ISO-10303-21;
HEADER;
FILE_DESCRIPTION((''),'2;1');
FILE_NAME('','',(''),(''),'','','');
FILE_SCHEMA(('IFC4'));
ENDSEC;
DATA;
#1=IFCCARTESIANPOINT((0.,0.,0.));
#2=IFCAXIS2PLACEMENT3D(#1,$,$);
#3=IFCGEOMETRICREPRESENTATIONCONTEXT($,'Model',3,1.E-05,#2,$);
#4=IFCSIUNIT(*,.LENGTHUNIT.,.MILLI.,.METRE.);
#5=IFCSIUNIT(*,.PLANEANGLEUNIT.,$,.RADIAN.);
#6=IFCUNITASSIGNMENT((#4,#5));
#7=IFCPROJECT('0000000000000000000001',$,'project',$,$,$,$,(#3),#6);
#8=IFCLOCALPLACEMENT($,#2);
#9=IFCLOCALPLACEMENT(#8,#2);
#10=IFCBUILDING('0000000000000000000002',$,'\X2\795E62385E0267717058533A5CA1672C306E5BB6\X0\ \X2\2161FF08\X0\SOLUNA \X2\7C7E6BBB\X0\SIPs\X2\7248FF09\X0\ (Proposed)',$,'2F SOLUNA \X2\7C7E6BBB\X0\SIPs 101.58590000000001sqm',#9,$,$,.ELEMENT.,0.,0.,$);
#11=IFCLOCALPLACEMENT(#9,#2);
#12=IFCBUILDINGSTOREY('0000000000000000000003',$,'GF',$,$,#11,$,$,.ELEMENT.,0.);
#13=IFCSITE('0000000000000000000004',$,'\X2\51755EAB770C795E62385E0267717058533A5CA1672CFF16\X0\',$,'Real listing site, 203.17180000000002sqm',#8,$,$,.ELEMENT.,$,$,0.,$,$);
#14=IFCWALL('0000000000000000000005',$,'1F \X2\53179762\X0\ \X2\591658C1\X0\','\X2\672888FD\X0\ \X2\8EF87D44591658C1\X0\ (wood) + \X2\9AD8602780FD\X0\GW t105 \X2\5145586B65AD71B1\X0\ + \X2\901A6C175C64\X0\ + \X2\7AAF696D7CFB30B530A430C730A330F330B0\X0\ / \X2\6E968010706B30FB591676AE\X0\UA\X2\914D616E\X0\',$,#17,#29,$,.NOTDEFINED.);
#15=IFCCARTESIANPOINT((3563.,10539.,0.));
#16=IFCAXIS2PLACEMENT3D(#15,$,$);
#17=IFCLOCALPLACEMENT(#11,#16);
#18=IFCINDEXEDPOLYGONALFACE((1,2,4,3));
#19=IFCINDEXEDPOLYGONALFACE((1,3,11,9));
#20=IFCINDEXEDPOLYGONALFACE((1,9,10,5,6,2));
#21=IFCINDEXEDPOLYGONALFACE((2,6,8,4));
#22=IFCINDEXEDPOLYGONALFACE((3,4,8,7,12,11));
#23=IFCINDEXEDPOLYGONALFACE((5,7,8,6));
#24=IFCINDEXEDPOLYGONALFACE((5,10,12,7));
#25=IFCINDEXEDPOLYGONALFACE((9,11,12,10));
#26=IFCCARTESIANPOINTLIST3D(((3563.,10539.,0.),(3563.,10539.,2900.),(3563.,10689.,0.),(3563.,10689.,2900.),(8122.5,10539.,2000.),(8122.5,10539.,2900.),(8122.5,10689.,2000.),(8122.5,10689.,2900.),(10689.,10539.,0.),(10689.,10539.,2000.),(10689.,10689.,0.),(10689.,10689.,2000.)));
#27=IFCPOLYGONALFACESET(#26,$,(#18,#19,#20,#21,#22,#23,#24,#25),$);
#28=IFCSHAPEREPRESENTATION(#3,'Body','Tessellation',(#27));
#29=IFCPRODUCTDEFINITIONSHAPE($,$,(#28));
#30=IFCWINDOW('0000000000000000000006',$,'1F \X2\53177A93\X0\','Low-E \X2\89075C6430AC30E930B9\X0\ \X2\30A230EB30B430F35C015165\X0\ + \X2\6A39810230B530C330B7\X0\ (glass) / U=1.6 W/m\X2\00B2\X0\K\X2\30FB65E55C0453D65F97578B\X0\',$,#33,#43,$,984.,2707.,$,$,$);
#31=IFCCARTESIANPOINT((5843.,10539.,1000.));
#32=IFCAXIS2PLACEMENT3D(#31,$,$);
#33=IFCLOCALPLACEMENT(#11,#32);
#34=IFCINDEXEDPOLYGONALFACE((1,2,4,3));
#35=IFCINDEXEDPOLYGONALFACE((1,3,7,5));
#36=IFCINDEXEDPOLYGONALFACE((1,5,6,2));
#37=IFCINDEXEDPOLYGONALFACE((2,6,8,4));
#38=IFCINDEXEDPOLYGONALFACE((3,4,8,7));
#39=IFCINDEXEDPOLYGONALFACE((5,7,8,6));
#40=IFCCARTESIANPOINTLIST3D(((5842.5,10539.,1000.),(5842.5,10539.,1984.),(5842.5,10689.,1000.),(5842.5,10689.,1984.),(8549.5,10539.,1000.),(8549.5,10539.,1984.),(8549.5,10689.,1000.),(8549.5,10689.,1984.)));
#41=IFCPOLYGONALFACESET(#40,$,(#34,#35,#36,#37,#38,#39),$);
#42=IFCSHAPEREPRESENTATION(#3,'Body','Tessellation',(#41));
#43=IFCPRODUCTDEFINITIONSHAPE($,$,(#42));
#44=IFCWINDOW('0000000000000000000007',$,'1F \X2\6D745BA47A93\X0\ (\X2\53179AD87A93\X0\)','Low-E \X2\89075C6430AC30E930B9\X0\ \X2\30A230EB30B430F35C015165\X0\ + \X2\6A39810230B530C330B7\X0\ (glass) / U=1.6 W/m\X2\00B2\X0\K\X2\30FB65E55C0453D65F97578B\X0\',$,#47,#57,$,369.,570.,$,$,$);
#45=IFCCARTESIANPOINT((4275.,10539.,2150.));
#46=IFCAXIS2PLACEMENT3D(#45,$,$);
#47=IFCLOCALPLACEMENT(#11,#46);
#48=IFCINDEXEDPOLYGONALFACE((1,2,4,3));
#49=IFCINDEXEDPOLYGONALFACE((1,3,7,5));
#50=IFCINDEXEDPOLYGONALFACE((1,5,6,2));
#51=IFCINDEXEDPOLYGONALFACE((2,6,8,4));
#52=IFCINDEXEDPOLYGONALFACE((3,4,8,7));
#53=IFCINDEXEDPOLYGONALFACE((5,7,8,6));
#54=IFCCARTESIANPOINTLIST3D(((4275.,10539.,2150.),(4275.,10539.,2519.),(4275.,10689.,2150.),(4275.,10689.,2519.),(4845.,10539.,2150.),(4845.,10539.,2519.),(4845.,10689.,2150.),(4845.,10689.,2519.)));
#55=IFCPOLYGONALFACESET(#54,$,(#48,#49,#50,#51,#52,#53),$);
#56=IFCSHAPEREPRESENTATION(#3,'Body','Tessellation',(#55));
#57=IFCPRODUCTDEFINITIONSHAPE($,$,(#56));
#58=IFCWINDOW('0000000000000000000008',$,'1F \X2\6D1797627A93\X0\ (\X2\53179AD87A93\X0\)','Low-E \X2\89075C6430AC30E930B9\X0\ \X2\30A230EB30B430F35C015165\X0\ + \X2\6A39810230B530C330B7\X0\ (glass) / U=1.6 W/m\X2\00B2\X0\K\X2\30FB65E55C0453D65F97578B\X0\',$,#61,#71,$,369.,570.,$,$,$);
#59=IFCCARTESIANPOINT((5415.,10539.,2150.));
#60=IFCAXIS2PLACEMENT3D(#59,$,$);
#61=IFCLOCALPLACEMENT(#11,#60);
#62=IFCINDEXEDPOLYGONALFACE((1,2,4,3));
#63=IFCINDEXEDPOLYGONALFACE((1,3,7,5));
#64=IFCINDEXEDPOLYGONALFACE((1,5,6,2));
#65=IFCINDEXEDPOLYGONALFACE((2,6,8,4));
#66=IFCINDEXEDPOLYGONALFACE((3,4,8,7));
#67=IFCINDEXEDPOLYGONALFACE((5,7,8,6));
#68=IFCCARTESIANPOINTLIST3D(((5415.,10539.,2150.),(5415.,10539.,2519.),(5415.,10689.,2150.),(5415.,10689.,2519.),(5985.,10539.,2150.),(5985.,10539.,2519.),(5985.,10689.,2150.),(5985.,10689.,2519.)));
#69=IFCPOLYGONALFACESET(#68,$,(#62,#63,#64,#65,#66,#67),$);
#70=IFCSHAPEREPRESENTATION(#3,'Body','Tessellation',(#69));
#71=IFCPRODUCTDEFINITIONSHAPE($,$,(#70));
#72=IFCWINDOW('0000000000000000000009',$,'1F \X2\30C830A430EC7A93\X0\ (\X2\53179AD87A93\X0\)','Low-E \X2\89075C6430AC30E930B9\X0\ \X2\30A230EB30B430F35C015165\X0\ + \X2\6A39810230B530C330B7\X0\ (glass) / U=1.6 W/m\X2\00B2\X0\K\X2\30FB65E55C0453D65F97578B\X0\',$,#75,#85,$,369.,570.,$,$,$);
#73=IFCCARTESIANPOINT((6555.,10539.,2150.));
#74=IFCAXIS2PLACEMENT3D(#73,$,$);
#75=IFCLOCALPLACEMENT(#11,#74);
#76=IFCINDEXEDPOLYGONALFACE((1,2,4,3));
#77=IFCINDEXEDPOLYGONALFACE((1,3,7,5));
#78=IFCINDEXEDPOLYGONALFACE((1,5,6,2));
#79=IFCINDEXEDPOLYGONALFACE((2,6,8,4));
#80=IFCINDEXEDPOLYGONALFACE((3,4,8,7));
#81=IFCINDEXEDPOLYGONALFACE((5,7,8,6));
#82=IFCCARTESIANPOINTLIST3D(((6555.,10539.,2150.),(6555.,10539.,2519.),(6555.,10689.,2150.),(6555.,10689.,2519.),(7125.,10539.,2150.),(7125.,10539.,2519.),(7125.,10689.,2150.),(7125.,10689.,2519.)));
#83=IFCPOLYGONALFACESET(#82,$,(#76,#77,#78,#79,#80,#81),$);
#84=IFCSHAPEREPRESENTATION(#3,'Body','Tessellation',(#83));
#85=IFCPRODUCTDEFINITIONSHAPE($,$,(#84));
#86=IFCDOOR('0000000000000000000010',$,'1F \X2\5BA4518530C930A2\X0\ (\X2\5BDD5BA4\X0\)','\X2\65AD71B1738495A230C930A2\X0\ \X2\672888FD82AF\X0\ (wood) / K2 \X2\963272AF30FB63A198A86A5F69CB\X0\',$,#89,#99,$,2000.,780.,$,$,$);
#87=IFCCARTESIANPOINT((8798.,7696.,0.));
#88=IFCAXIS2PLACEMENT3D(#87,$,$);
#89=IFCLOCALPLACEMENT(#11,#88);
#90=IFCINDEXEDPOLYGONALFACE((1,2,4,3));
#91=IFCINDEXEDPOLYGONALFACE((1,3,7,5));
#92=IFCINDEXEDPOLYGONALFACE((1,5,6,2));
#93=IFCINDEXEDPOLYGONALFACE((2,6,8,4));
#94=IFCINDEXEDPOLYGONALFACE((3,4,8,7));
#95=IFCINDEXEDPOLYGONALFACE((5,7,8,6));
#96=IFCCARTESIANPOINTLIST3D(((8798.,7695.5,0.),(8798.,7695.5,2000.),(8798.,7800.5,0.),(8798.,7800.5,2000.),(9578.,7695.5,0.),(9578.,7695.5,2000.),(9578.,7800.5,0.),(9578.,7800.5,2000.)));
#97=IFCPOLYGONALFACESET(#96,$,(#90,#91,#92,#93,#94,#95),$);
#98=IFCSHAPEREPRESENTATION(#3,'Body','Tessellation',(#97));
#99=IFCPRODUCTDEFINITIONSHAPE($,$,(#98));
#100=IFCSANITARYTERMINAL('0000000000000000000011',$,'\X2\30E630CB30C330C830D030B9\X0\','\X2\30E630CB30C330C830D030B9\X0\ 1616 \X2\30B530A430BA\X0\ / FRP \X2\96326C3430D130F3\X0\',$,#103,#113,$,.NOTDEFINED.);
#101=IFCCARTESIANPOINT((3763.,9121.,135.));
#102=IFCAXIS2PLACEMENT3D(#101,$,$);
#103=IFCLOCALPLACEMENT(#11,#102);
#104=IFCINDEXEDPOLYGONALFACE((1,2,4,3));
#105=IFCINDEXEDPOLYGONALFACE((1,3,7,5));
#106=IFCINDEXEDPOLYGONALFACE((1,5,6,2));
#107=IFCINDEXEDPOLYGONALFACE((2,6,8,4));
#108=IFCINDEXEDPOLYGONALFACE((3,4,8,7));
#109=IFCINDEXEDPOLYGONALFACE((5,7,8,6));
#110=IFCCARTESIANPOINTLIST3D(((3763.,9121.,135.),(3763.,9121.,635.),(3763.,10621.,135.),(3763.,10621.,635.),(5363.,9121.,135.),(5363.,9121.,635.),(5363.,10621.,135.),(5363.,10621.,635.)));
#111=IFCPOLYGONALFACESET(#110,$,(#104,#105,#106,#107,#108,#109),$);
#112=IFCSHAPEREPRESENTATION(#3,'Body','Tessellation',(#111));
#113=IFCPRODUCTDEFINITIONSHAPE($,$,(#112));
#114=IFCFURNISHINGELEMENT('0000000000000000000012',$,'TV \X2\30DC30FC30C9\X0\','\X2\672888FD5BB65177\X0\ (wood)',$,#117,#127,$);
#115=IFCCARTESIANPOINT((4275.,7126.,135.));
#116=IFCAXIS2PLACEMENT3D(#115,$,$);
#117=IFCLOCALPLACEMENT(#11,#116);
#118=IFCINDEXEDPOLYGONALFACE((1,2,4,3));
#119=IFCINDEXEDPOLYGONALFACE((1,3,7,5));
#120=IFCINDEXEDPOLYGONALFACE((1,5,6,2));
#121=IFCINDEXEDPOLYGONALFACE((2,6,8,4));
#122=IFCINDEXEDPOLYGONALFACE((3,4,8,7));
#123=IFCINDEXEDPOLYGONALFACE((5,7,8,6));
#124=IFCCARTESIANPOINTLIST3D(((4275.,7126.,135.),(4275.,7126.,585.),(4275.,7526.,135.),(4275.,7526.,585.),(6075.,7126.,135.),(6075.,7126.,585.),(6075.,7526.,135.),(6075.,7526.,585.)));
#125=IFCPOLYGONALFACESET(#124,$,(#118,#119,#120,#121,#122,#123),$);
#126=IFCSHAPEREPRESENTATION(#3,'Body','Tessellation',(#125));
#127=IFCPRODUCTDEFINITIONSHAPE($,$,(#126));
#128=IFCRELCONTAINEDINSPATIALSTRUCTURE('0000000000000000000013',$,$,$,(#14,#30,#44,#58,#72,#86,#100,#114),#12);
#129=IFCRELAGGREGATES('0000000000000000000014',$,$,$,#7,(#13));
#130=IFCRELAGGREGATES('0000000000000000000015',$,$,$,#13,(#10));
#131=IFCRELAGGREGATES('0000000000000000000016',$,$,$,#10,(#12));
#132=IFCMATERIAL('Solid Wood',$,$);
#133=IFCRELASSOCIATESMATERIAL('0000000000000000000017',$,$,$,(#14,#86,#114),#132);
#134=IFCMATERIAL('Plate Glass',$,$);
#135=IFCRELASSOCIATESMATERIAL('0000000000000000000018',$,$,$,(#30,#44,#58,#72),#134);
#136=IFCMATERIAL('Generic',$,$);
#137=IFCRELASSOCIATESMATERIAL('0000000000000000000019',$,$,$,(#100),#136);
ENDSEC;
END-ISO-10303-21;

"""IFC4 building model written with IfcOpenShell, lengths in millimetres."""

from ifc_helpers import new_model, si_unit, frame, frame_2d, origin, place, context, project, spatial, rectangle, extrude, material, element, fill, save


model = new_model("IFC4")

# Units and contexts
model_context = context("Model", 3, precision=1e-05, world=origin())
ifc_project = project(units=[si_unit("LENGTHUNIT", "METRE", prefix="MILLI"), si_unit("PLANEANGLEUNIT", "RADIAN")], contexts=[model_context])

# Site, building, storey
site_placement = place(None, origin())
site = spatial("IfcSite", under=ifc_project, at=site_placement, Name="兵庫県神戸市東灘区岡本６", ObjectType="Real listing site, 203.17180000000002sqm", CompositionType="ELEMENT", RefElevation=0.0)
building_placement = place(site_placement, origin())
building = spatial("IfcBuilding", under=site, at=building_placement, Name="神戸市東灘区岡本の家 Ⅱ（SOLUNA 籾殻SIPs版） (Proposed)", ObjectType="2F SOLUNA 籾殻SIPs 101.58590000000001sqm", CompositionType="ELEMENT", ElevationOfRefHeight=0.0, ElevationOfTerrain=0.0)
storey_placement = place(building_placement, origin())
storey = spatial("IfcBuildingStorey", under=building, at=storey_placement, Name="GF", CompositionType="ELEMENT", Elevation=0.0)

# Wall, openings, windows
ifc_material_1 = material(Name="Solid Wood")
wall_1_placement = place(storey_placement, frame((3563.0, 10539.0, 0.0)))
wall_1 = element("IfcWall", 1, at=wall_1_placement, inside=storey, material=ifc_material_1, Name="1F 北面 外壁", Description="木製 軸組外壁 (wood) + 高性能GW t105 充填断熱 + 通気層 + 窯業系サイディング / 準耐火・外皮UA配慮", PredefinedType="NOTDEFINED", context=model_context, shape_type="SweptSolid", body=[
    extrude(rectangle(XDim=7126.0, YDim=150.0, at=frame_2d((3563.0, 75.0))), frame((3563.0, 10539.0, 0.0)), (0.0, 0.0, 1.0), 2900.0),
])
opening_1_placement = place(storey_placement, frame((5843.0, 10539.0, 1000.0)))
opening_1 = element("IfcOpeningElement", 2, at=opening_1_placement, cuts=wall_1, PredefinedType="NOTDEFINED", context=model_context, shape_type="SweptSolid", body=[
    extrude(rectangle(XDim=2707.0, YDim=150.0, at=frame_2d((1353.0, 75.0))), frame((5843.0, 10539.0, 1000.0)), (0.0, 0.0, 1.0), 984.0),
])
opening_2_placement = place(storey_placement, frame((4275.0, 10539.0, 2150.0)))
opening_2 = element("IfcOpeningElement", 3, at=opening_2_placement, cuts=wall_1, PredefinedType="NOTDEFINED", context=model_context, shape_type="SweptSolid", body=[
    extrude(rectangle(XDim=570.0, YDim=150.0, at=frame_2d((285.0, 75.0))), frame((4275.0, 10539.0, 2150.0)), (0.0, 0.0, 1.0), 369.0),
])
opening_3_placement = place(storey_placement, frame((5415.0, 10539.0, 2150.0)))
opening_3 = element("IfcOpeningElement", 4, at=opening_3_placement, cuts=wall_1, PredefinedType="NOTDEFINED", context=model_context, shape_type="SweptSolid", body=[
    extrude(rectangle(XDim=570.0, YDim=150.0, at=frame_2d((285.0, 75.0))), frame((5415.0, 10539.0, 2150.0)), (0.0, 0.0, 1.0), 369.0),
])
opening_4_placement = place(storey_placement, frame((6555.0, 10539.0, 2150.0)))
opening_4 = element("IfcOpeningElement", 5, at=opening_4_placement, cuts=wall_1, PredefinedType="NOTDEFINED", context=model_context, shape_type="SweptSolid", body=[
    extrude(rectangle(XDim=570.0, YDim=150.0, at=frame_2d((285.0, 75.0))), frame((6555.0, 10539.0, 2150.0)), (0.0, 0.0, 1.0), 369.0),
])
ifc_material_2 = material(Name="Plate Glass")
window_1_placement = place(storey_placement, frame((5843.0, 10539.0, 1000.0)))
window_1 = element("IfcWindow", 6, at=window_1_placement, inside=storey, material=ifc_material_2, Name="1F 北窓", Description="Low-E 複層ガラス アルゴン封入 + 樹脂サッシ (glass) / U=1.6 W/m²K・日射取得型", OverallHeight=984.0, OverallWidth=2707.0, context=model_context, shape_type="SweptSolid", body=[
    extrude(rectangle(XDim=2707.0, YDim=150.0, at=frame_2d((1353.0, 75.0))), frame((5843.0, 10539.0, 1000.0)), (0.0, 0.0, 1.0), 984.0),
])
fill(opening_1, window_1)
window_2_placement = place(storey_placement, frame((4275.0, 10539.0, 2150.0)))
window_2 = element("IfcWindow", 7, at=window_2_placement, inside=storey, material=ifc_material_2, Name="1F 浴室窓 (北高窓)", Description="Low-E 複層ガラス アルゴン封入 + 樹脂サッシ (glass) / U=1.6 W/m²K・日射取得型", OverallHeight=369.0, OverallWidth=570.0, context=model_context, shape_type="SweptSolid", body=[
    extrude(rectangle(XDim=570.0, YDim=150.0, at=frame_2d((285.0, 75.0))), frame((4275.0, 10539.0, 2150.0)), (0.0, 0.0, 1.0), 369.0),
])
fill(opening_2, window_2)
window_3_placement = place(storey_placement, frame((5415.0, 10539.0, 2150.0)))
window_3 = element("IfcWindow", 8, at=window_3_placement, inside=storey, material=ifc_material_2, Name="1F 洗面窓 (北高窓)", Description="Low-E 複層ガラス アルゴン封入 + 樹脂サッシ (glass) / U=1.6 W/m²K・日射取得型", OverallHeight=369.0, OverallWidth=570.0, context=model_context, shape_type="SweptSolid", body=[
    extrude(rectangle(XDim=570.0, YDim=150.0, at=frame_2d((285.0, 75.0))), frame((5415.0, 10539.0, 2150.0)), (0.0, 0.0, 1.0), 369.0),
])
fill(opening_3, window_3)
window_4_placement = place(storey_placement, frame((6555.0, 10539.0, 2150.0)))
window_4 = element("IfcWindow", 9, at=window_4_placement, inside=storey, material=ifc_material_2, Name="1F トイレ窓 (北高窓)", Description="Low-E 複層ガラス アルゴン封入 + 樹脂サッシ (glass) / U=1.6 W/m²K・日射取得型", OverallHeight=369.0, OverallWidth=570.0, context=model_context, shape_type="SweptSolid", body=[
    extrude(rectangle(XDim=570.0, YDim=150.0, at=frame_2d((285.0, 75.0))), frame((6555.0, 10539.0, 2150.0)), (0.0, 0.0, 1.0), 369.0),
])
fill(opening_4, window_4)

# Door
door_1_placement = place(storey_placement, frame((8798.0, 7696.0, 0.0)))
element("IfcDoor", 10, at=door_1_placement, inside=storey, material=ifc_material_1, Name="1F 室内ドア (寝室)", Description="断熱玄関ドア 木製芯 (wood) / K2 防犯・採風機構", OverallHeight=2000.0, OverallWidth=780.0, context=model_context, shape_type="SweptSolid", body=[
    extrude(rectangle(XDim=780.0, YDim=105.0, at=frame_2d((390.0, 52.0))), frame((8798.0, 7696.0, 0.0)), (0.0, 0.0, 1.0), 2000.0),
])

# Sanitary terminal
ifc_material_3 = material(Name="Generic")
sanitary_terminal_placement = place(storey_placement, frame((3763.0, 9121.0, 135.0)))
element("IfcSanitaryTerminal", 11, at=sanitary_terminal_placement, inside=storey, material=ifc_material_3, Name="ユニットバス", Description="ユニットバス 1616 サイズ / FRP 防水パン", PredefinedType="NOTDEFINED", context=model_context, shape_type="SweptSolid", body=[
    extrude(rectangle(XDim=1600.0, YDim=1500.0, at=frame_2d((800.0, 750.0))), frame((3763.0, 9121.0, 135.0)), (0.0, 0.0, 1.0), 500.0),
])

# Furnishing element
furnishing_placement = place(storey_placement, frame((4275.0, 7126.0, 135.0)))
element("IfcFurnishingElement", 12, at=furnishing_placement, inside=storey, material=ifc_material_1, Name="TV ボード", Description="木製家具 (wood)", context=model_context, shape_type="SweptSolid", body=[
    extrude(rectangle(XDim=1800.0, YDim=400.0, at=frame_2d((900.0, 200.0))), frame((4275.0, 7126.0, 135.0)), (0.0, 0.0, 1.0), 450.0),
])

save(model, "model.ifc")
